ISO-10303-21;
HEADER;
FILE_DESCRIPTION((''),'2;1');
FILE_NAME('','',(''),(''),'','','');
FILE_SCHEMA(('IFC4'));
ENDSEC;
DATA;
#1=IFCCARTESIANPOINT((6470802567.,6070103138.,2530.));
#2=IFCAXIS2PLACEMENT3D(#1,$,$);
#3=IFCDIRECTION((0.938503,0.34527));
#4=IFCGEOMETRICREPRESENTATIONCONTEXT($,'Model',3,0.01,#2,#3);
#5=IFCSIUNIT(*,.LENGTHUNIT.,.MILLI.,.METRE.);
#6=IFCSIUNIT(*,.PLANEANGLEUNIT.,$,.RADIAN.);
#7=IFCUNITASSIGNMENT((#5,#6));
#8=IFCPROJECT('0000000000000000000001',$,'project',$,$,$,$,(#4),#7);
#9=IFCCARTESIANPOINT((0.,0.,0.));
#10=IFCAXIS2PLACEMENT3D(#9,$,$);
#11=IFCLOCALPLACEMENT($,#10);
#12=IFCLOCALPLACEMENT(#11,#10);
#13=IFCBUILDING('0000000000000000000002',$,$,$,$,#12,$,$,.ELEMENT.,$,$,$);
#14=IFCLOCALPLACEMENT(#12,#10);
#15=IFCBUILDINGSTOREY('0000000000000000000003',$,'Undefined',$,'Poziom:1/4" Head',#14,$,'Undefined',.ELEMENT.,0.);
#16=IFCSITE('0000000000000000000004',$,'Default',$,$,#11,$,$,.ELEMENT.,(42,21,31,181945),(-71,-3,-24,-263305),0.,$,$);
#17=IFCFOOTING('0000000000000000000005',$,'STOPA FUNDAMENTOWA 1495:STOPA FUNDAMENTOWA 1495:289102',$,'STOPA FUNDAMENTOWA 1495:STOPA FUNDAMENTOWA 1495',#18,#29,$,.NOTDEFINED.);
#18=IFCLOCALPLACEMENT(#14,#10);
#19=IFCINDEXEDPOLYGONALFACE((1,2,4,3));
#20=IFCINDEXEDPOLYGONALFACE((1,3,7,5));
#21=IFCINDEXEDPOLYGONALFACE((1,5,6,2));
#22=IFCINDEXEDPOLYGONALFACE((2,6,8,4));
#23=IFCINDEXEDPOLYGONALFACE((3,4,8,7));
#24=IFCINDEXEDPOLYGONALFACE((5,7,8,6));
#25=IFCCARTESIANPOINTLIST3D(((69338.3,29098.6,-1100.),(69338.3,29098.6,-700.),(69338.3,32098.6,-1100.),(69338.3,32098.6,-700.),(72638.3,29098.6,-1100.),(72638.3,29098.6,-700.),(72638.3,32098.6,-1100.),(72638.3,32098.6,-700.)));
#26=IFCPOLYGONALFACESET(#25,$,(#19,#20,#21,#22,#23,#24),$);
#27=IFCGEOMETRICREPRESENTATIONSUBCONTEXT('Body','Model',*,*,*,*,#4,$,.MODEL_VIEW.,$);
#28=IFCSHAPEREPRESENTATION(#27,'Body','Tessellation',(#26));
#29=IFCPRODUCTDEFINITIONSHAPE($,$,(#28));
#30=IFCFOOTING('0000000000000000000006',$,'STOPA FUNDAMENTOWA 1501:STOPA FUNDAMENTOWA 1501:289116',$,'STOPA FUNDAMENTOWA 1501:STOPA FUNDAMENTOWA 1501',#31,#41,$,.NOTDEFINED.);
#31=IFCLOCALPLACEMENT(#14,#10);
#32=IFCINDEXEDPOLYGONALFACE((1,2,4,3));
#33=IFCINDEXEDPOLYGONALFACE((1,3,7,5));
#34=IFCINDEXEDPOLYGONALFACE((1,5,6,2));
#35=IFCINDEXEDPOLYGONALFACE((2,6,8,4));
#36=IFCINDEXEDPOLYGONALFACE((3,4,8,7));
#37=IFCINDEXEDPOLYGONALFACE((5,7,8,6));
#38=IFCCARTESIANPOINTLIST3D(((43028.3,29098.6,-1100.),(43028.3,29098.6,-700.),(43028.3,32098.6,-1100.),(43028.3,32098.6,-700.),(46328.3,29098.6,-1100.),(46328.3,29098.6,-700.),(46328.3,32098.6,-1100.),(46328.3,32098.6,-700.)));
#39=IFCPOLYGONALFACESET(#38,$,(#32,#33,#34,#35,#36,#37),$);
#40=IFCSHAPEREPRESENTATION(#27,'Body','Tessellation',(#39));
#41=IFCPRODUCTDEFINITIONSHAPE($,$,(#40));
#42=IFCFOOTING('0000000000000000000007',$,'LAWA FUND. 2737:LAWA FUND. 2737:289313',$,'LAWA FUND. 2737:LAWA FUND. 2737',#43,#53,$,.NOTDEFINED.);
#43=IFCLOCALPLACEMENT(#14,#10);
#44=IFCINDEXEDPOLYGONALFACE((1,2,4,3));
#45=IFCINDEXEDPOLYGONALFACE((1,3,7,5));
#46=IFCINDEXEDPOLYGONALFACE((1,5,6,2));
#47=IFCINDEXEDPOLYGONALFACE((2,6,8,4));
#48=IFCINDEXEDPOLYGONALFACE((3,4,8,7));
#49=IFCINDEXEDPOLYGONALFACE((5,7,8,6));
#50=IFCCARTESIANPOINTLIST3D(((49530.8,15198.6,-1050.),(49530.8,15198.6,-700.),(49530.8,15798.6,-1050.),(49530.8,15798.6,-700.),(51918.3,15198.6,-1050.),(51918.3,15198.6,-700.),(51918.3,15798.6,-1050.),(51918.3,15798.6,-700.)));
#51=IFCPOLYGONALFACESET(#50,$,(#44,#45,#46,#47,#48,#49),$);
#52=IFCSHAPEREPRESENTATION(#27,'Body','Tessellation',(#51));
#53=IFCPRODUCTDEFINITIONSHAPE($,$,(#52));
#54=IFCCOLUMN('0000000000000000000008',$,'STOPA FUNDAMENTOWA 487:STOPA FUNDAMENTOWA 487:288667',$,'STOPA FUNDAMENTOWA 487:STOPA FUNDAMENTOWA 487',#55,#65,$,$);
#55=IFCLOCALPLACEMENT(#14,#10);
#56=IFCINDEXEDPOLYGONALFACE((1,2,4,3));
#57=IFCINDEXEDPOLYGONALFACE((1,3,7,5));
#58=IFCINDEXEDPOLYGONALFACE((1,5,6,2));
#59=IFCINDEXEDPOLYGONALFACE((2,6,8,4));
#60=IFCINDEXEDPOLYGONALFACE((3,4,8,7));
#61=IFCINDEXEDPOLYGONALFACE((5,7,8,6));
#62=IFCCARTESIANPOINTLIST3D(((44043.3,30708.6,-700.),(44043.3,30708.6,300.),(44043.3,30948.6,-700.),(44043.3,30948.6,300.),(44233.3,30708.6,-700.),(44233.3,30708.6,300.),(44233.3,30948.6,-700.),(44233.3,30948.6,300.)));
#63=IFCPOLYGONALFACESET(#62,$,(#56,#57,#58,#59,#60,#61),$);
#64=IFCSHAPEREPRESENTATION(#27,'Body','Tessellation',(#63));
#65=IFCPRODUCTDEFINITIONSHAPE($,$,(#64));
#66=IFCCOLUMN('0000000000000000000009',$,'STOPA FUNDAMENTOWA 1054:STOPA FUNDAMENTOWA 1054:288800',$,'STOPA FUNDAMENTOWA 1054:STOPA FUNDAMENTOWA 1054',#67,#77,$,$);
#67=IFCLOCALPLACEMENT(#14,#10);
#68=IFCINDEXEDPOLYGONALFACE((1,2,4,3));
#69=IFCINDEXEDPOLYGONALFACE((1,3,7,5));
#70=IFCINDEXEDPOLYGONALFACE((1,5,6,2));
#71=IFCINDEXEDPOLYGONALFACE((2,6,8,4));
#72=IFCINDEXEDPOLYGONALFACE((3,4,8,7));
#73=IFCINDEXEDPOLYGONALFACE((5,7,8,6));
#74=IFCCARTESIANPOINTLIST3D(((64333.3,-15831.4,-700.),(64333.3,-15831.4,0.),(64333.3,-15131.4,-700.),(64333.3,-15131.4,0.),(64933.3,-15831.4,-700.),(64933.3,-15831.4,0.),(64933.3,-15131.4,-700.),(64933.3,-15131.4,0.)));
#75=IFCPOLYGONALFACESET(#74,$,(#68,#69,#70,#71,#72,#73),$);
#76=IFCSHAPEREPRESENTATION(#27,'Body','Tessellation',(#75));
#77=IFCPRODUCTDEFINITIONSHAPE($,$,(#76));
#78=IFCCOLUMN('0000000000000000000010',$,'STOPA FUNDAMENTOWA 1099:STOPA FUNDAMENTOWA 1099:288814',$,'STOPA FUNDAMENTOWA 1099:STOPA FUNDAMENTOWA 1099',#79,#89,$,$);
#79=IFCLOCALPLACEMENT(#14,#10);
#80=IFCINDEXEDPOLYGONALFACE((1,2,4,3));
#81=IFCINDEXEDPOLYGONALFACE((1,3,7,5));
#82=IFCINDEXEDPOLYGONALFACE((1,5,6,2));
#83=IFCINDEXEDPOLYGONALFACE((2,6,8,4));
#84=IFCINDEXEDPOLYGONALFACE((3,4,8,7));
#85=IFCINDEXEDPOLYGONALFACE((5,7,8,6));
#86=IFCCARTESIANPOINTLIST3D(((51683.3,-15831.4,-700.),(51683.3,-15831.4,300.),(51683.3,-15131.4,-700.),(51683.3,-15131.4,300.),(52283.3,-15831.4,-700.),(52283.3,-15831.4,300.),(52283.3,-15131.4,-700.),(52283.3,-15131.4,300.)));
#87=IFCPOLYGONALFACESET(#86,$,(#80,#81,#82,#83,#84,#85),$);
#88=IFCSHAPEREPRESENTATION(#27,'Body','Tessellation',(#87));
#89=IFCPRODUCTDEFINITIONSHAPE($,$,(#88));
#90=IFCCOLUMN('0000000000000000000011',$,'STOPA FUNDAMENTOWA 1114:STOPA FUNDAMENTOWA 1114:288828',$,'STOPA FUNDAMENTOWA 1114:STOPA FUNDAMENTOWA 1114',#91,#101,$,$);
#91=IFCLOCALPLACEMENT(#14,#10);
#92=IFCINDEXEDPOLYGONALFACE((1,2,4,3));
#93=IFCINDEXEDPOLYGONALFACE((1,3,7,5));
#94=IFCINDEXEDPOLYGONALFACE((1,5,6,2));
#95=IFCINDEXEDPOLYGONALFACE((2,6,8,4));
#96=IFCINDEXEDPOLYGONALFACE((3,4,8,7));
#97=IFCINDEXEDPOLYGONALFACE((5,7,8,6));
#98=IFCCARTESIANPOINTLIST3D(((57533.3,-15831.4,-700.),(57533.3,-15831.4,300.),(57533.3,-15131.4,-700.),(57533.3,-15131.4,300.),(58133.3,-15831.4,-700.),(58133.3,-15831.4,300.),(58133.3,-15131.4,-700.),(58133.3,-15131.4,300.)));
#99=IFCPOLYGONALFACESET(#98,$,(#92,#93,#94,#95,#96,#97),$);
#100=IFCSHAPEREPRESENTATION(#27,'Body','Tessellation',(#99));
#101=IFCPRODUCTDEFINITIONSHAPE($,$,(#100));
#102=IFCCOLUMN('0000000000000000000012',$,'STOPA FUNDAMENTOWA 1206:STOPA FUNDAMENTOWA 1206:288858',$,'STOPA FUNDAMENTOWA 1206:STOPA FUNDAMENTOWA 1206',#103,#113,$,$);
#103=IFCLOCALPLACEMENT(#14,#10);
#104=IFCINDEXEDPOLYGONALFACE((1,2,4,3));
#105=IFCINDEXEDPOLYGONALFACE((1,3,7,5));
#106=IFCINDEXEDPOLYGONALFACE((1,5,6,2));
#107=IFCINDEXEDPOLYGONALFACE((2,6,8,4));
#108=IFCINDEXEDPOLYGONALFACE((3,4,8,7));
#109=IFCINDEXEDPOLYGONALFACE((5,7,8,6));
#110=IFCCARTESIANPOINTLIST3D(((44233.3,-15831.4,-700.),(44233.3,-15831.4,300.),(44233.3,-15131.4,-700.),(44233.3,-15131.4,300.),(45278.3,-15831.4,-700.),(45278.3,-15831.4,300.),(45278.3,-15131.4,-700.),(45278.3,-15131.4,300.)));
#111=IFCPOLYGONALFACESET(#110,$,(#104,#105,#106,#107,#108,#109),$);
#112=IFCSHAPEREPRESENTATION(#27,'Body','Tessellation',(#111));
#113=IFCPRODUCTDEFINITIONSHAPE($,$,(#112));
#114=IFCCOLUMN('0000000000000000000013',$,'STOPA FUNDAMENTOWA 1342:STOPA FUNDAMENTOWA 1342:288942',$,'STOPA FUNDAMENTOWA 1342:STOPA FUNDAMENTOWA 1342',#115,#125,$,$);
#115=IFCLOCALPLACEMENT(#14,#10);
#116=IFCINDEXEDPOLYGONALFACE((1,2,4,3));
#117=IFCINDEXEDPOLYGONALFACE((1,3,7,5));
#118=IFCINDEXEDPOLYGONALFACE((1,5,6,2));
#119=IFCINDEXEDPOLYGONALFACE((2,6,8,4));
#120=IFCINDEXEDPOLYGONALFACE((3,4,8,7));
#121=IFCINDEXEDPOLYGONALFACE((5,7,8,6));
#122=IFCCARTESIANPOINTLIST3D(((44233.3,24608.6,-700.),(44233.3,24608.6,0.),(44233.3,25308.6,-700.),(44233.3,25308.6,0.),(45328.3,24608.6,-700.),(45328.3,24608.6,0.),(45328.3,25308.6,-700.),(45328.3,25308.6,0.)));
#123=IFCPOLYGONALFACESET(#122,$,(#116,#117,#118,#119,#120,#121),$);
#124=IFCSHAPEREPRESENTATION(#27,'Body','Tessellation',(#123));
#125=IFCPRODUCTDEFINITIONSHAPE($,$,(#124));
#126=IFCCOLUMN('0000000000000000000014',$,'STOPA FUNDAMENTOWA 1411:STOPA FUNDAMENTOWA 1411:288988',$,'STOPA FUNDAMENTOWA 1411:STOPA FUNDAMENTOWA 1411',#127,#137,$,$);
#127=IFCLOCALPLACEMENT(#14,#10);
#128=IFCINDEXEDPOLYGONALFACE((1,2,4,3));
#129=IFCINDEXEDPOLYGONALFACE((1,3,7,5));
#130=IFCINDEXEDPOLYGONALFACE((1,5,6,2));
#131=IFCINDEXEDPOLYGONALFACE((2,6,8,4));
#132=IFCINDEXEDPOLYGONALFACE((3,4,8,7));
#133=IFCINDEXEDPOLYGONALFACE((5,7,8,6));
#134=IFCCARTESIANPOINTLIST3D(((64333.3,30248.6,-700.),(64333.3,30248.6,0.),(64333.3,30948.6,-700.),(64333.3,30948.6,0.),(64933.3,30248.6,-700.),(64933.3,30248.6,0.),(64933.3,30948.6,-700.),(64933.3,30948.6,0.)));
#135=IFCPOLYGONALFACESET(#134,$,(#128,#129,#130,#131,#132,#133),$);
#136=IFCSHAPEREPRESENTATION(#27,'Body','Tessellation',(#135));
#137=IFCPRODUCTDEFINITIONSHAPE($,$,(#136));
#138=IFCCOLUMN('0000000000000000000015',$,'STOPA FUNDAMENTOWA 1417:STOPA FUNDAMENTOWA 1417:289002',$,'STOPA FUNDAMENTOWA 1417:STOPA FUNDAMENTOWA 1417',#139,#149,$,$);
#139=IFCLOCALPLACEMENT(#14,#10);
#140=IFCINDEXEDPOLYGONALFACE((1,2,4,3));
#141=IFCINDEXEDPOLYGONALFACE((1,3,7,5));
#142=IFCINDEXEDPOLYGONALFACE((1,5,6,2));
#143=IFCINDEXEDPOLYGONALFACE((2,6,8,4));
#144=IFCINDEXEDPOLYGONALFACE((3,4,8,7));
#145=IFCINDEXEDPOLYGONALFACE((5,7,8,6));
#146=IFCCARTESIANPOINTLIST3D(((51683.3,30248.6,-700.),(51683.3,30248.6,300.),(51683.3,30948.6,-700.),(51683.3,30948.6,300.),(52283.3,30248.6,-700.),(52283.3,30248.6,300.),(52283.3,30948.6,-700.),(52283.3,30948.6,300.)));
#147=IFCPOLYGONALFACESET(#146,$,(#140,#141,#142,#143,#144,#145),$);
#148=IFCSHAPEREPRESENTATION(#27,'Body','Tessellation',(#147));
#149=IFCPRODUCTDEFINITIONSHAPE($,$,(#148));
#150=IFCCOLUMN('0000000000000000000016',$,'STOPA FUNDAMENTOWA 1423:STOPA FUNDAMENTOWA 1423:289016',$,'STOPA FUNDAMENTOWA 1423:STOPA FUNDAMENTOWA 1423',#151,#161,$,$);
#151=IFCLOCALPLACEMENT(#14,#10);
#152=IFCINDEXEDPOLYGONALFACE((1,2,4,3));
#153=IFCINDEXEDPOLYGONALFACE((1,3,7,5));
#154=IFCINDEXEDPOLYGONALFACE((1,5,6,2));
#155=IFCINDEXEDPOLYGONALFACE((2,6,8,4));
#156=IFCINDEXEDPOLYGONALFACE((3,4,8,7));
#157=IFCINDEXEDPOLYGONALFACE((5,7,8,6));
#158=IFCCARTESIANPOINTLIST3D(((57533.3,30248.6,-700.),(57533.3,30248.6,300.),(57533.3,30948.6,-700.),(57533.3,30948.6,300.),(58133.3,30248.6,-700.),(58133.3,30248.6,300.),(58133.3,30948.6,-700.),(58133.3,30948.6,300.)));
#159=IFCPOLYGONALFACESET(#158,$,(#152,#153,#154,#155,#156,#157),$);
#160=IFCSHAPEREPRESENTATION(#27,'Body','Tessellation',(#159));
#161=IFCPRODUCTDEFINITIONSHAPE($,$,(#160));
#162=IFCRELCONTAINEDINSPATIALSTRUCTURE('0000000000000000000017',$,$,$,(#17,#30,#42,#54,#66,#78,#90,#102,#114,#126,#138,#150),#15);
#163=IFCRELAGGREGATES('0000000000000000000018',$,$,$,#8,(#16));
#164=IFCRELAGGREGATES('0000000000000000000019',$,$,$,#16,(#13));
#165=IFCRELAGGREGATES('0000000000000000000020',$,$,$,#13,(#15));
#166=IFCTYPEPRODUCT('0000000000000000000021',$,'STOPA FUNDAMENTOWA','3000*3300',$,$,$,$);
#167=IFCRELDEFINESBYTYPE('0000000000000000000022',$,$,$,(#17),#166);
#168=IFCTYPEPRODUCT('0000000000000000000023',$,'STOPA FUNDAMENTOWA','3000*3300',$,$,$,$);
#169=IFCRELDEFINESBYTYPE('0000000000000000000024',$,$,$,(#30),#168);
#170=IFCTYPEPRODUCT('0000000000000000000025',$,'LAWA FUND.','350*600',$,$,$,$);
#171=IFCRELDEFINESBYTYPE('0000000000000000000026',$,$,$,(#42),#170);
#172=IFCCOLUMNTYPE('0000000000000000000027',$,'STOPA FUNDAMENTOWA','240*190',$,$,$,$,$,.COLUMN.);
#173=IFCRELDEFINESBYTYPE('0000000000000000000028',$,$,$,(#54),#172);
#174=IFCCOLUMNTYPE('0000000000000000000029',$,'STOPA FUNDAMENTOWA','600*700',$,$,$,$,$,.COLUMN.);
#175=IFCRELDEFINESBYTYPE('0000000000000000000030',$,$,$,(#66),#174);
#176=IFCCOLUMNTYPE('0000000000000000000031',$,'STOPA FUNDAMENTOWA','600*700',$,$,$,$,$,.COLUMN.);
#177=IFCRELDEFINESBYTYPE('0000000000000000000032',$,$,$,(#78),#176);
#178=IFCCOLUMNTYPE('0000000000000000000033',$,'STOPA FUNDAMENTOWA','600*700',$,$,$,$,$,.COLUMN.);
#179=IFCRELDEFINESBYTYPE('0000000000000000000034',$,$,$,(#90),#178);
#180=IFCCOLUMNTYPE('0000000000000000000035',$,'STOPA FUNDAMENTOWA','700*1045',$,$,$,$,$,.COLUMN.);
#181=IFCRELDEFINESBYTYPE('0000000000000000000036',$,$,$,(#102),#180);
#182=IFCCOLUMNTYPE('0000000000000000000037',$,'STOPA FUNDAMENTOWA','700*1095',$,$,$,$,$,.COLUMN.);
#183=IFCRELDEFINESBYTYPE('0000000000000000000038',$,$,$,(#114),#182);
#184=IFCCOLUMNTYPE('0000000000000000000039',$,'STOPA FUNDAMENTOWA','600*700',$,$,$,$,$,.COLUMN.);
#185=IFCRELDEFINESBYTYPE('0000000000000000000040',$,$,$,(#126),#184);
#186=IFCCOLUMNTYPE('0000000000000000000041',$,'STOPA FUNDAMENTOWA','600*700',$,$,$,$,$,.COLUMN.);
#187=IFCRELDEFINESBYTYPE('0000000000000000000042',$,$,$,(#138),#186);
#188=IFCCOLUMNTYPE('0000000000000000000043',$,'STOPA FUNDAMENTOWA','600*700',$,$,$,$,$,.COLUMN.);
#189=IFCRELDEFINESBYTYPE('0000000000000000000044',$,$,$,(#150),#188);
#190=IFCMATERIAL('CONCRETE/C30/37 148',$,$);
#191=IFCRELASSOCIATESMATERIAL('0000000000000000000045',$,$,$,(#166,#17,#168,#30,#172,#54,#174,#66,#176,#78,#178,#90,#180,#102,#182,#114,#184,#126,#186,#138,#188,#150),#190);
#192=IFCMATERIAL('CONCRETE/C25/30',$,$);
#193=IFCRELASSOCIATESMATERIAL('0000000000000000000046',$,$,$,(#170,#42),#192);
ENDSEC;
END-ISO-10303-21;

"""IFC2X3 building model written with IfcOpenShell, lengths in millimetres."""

from ifc_helpers import new_model, si_unit, direction, frame, frame_2d, origin, origin_2d_with_axis, place, context, subcontext, project, spatial, rectangle, extrude, source, transform, mapped, material, type_object, type_shapes, element, save


model = new_model("IFC2X3")

# Units and contexts
model_context = context("Model", 3, precision=0.01, world=frame((6470802567.0, 6070103138.0, 2530.0)), true_north=direction((0.938503, 0.34527)))
body_context = subcontext(model_context, "Body", "Model", "MODEL_VIEW")
ifc_project = project(units=[si_unit("LENGTHUNIT", "METRE", prefix="MILLI"), si_unit("PLANEANGLEUNIT", "RADIAN")], contexts=[model_context])

# Site, building, storey
site_placement = place(None, origin())
site = spatial("IfcSite", under=ifc_project, at=site_placement, Name="Default", CompositionType="ELEMENT", RefLatitude=(42, 21, 31, 181945), RefLongitude=(-71, -3, -24, -263305), RefElevation=0.0)
building_placement = place(site_placement, origin())
building = spatial("IfcBuilding", under=site, at=building_placement, CompositionType="ELEMENT")
storey_placement = place(building_placement, origin())
storey = spatial("IfcBuildingStorey", under=building, at=storey_placement, Name="Undefined", ObjectType="Poziom:1/4\" Head", LongName="Undefined", CompositionType="ELEMENT", Elevation=0.0)

# Footings
ifc_material_1 = material(Name="CONCRETE/C25/30")
ifc_material_2 = material(Name="CONCRETE/C30/37 148")
type_product_1 = type_object("IfcTypeProduct", Name="STOPA FUNDAMENTOWA", Description="3000*3300", material=ifc_material_2)
shared_shape_1 = source(origin(), body_context, "Body", "SweptSolid", [
    extrude(rectangle(XDim=3000.0, YDim=3300.0, at=origin_2d_with_axis()), frame((70988.3, 30598.6, -1100.0), z_axis=(0.0, 0.0, 1.0), x_axis=(0.0, 1.0, 0.0)), (0.0, 0.0, 1.0), 400.0),
])
type_shapes(type_product_1, [shared_shape_1])
footing_1_placement = place(storey_placement, origin())
element("IfcFooting", 1, at=footing_1_placement, inside=storey, type_object=type_product_1, material=ifc_material_2, Name="STOPA FUNDAMENTOWA 1495:STOPA FUNDAMENTOWA 1495:289102", ObjectType="STOPA FUNDAMENTOWA 1495:STOPA FUNDAMENTOWA 1495", PredefinedType="NOTDEFINED", context=body_context, shape_type="MappedRepresentation", body=[
    mapped(shared_shape_1, transform((0.0, 0.0, 0.0), scale=1.0)),
])
type_product_2 = type_object("IfcTypeProduct", Name="STOPA FUNDAMENTOWA", Description="3000*3300", material=ifc_material_2)
shared_shape_2 = source(origin(), body_context, "Body", "SweptSolid", [
    extrude(rectangle(XDim=3000.0, YDim=3300.0, at=origin_2d_with_axis()), frame((44678.3, 30598.6, -1100.0), z_axis=(0.0, 0.0, 1.0), x_axis=(0.0, 1.0, 0.0)), (0.0, 0.0, 1.0), 400.0),
])
type_shapes(type_product_2, [shared_shape_2])
footing_2_placement = place(storey_placement, origin())
element("IfcFooting", 2, at=footing_2_placement, inside=storey, type_object=type_product_2, material=ifc_material_2, Name="STOPA FUNDAMENTOWA 1501:STOPA FUNDAMENTOWA 1501:289116", ObjectType="STOPA FUNDAMENTOWA 1501:STOPA FUNDAMENTOWA 1501", PredefinedType="NOTDEFINED", context=body_context, shape_type="MappedRepresentation", body=[
    mapped(shared_shape_2, transform((0.0, 0.0, 0.0), scale=1.0)),
])
type_product_3 = type_object("IfcTypeProduct", Name="LAWA FUND.", Description="350*600", material=ifc_material_1)
shared_shape_3 = source(origin(), body_context, "Body", "SweptSolid", [
    extrude(rectangle(XDim=600.0, YDim=2387.5, at=frame_2d((0.0, 0.0), x_axis=(1.0, 0.0))), frame((50724.5, 15498.6, -1050.0), z_axis=(0.0, 0.0, 1.0), x_axis=(0.0, 1.0, 0.0)), (0.0, 0.0, 1.0), 350.0),
])
type_shapes(type_product_3, [shared_shape_3])
footing_3_placement = place(storey_placement, origin())
element("IfcFooting", 3, at=footing_3_placement, inside=storey, type_object=type_product_3, material=ifc_material_1, Name="LAWA FUND. 2737:LAWA FUND. 2737:289313", ObjectType="LAWA FUND. 2737:LAWA FUND. 2737", PredefinedType="NOTDEFINED", context=body_context, shape_type="MappedRepresentation", body=[
    mapped(shared_shape_3, transform((0.0, 0.0, 0.0), scale=1.0)),
])

# Columns
column_type_1 = type_object("IfcColumnType", Name="STOPA FUNDAMENTOWA", Description="240*190", PredefinedType="COLUMN", material=ifc_material_2)
shared_shape_4 = source(origin(), body_context, "Body", "SweptSolid", [
    extrude(rectangle(XDim=240.0, YDim=190.0, at=frame_2d((0.0, 0.0), x_axis=(1.0, 0.0))), frame((44138.3, 30828.6, -700.0), z_axis=(0.0, 0.0, 1.0), x_axis=(0.0, 1.0, 0.0)), (0.0, 0.0, 1.0), 1000.0),
])
type_shapes(column_type_1, [shared_shape_4])
column_1_placement = place(storey_placement, origin())
element("IfcColumn", 4, at=column_1_placement, inside=storey, type_object=column_type_1, material=ifc_material_2, Name="STOPA FUNDAMENTOWA 487:STOPA FUNDAMENTOWA 487:288667", ObjectType="STOPA FUNDAMENTOWA 487:STOPA FUNDAMENTOWA 487", context=body_context, shape_type="MappedRepresentation", body=[
    mapped(shared_shape_4, transform((0.0, 0.0, 0.0), scale=1.0)),
])
column_type_2 = type_object("IfcColumnType", Name="STOPA FUNDAMENTOWA", Description="600*700", PredefinedType="COLUMN", material=ifc_material_2)
shared_shape_5 = source(origin(), body_context, "Body", "SweptSolid", [
    extrude(rectangle(XDim=600.0, YDim=700.0, at=frame_2d((0.0, 0.0), x_axis=(1.0, 0.0))), frame((64633.3, -15481.4, -700.0)), (0.0, 0.0, 1.0), 700.0),
])
type_shapes(column_type_2, [shared_shape_5])
column_2_placement = place(storey_placement, origin())
element("IfcColumn", 5, at=column_2_placement, inside=storey, type_object=column_type_2, material=ifc_material_2, Name="STOPA FUNDAMENTOWA 1054:STOPA FUNDAMENTOWA 1054:288800", ObjectType="STOPA FUNDAMENTOWA 1054:STOPA FUNDAMENTOWA 1054", context=body_context, shape_type="MappedRepresentation", body=[
    mapped(shared_shape_5, transform((0.0, 0.0, 0.0), scale=1.0)),
])
column_type_3 = type_object("IfcColumnType", Name="STOPA FUNDAMENTOWA", Description="600*700", PredefinedType="COLUMN", material=ifc_material_2)
shared_shape_6 = source(origin(), body_context, "Body", "SweptSolid", [
    extrude(rectangle(XDim=600.0, YDim=700.0, at=frame_2d((0.0, 0.0), x_axis=(1.0, 0.0))), frame((51983.3, -15481.4, -700.0)), (0.0, 0.0, 1.0), 1000.0),
])
type_shapes(column_type_3, [shared_shape_6])
column_3_placement = place(storey_placement, origin())
element("IfcColumn", 6, at=column_3_placement, inside=storey, type_object=column_type_3, material=ifc_material_2, Name="STOPA FUNDAMENTOWA 1099:STOPA FUNDAMENTOWA 1099:288814", ObjectType="STOPA FUNDAMENTOWA 1099:STOPA FUNDAMENTOWA 1099", context=body_context, shape_type="MappedRepresentation", body=[
    mapped(shared_shape_6, transform((0.0, 0.0, 0.0), scale=1.0)),
])
column_type_4 = type_object("IfcColumnType", Name="STOPA FUNDAMENTOWA", Description="600*700", PredefinedType="COLUMN", material=ifc_material_2)
shared_shape_7 = source(origin(), body_context, "Body", "SweptSolid", [
    extrude(rectangle(XDim=600.0, YDim=700.0, at=frame_2d((0.0, 0.0), x_axis=(1.0, 0.0))), frame((57833.3, -15481.4, -700.0)), (0.0, 0.0, 1.0), 1000.0),
])
type_shapes(column_type_4, [shared_shape_7])
column_4_placement = place(storey_placement, origin())
element("IfcColumn", 7, at=column_4_placement, inside=storey, type_object=column_type_4, material=ifc_material_2, Name="STOPA FUNDAMENTOWA 1114:STOPA FUNDAMENTOWA 1114:288828", ObjectType="STOPA FUNDAMENTOWA 1114:STOPA FUNDAMENTOWA 1114", context=body_context, shape_type="MappedRepresentation", body=[
    mapped(shared_shape_7, transform((0.0, 0.0, 0.0), scale=1.0)),
])
column_type_5 = type_object("IfcColumnType", Name="STOPA FUNDAMENTOWA", Description="700*1045", PredefinedType="COLUMN", material=ifc_material_2)
shared_shape_8 = source(origin(), body_context, "Body", "SweptSolid", [
    extrude(rectangle(XDim=700.0, YDim=1045.0, at=frame_2d((0.0, 0.0), x_axis=(1.0, 0.0))), frame((44755.8, -15481.4, -700.0), z_axis=(0.0, 0.0, 1.0), x_axis=(0.0, -1.0, 0.0)), (0.0, 0.0, 1.0), 1000.0),
])
type_shapes(column_type_5, [shared_shape_8])
column_5_placement = place(storey_placement, origin())
element("IfcColumn", 8, at=column_5_placement, inside=storey, type_object=column_type_5, material=ifc_material_2, Name="STOPA FUNDAMENTOWA 1206:STOPA FUNDAMENTOWA 1206:288858", ObjectType="STOPA FUNDAMENTOWA 1206:STOPA FUNDAMENTOWA 1206", context=body_context, shape_type="MappedRepresentation", body=[
    mapped(shared_shape_8, transform((0.0, 0.0, 0.0), scale=1.0)),
])
column_type_6 = type_object("IfcColumnType", Name="STOPA FUNDAMENTOWA", Description="700*1095", PredefinedType="COLUMN", material=ifc_material_2)
shared_shape_9 = source(origin(), body_context, "Body", "SweptSolid", [
    extrude(rectangle(XDim=700.0, YDim=1095.0, at=frame_2d((0.0, 0.0), x_axis=(1.0, 0.0))), frame((44780.8, 24958.6, -700.0), z_axis=(0.0, 0.0, 1.0), x_axis=(0.0, 1.0, 0.0)), (0.0, 0.0, 1.0), 700.0),
])
type_shapes(column_type_6, [shared_shape_9])
column_6_placement = place(storey_placement, origin())
element("IfcColumn", 9, at=column_6_placement, inside=storey, type_object=column_type_6, material=ifc_material_2, Name="STOPA FUNDAMENTOWA 1342:STOPA FUNDAMENTOWA 1342:288942", ObjectType="STOPA FUNDAMENTOWA 1342:STOPA FUNDAMENTOWA 1342", context=body_context, shape_type="MappedRepresentation", body=[
    mapped(shared_shape_9, transform((0.0, 0.0, 0.0), scale=1.0)),
])
column_type_7 = type_object("IfcColumnType", Name="STOPA FUNDAMENTOWA", Description="600*700", PredefinedType="COLUMN", material=ifc_material_2)
shared_shape_10 = source(origin(), body_context, "Body", "SweptSolid", [
    extrude(rectangle(XDim=600.0, YDim=700.0, at=origin_2d_with_axis()), frame((64633.3, 30598.6, -700.0)), (0.0, 0.0, 1.0), 700.0),
])
type_shapes(column_type_7, [shared_shape_10])
column_7_placement = place(storey_placement, origin())
element("IfcColumn", 10, at=column_7_placement, inside=storey, type_object=column_type_7, material=ifc_material_2, Name="STOPA FUNDAMENTOWA 1411:STOPA FUNDAMENTOWA 1411:288988", ObjectType="STOPA FUNDAMENTOWA 1411:STOPA FUNDAMENTOWA 1411", context=body_context, shape_type="MappedRepresentation", body=[
    mapped(shared_shape_10, transform((0.0, 0.0, 0.0), scale=1.0)),
])
column_type_8 = type_object("IfcColumnType", Name="STOPA FUNDAMENTOWA", Description="600*700", PredefinedType="COLUMN", material=ifc_material_2)
shared_shape_11 = source(origin(), body_context, "Body", "SweptSolid", [
    extrude(rectangle(XDim=600.0, YDim=700.0, at=frame_2d((0.0, 0.0), x_axis=(1.0, 0.0))), frame((51983.3, 30598.6, -700.0)), (0.0, 0.0, 1.0), 1000.0),
])
type_shapes(column_type_8, [shared_shape_11])
column_8_placement = place(storey_placement, origin())
element("IfcColumn", 11, at=column_8_placement, inside=storey, type_object=column_type_8, material=ifc_material_2, Name="STOPA FUNDAMENTOWA 1417:STOPA FUNDAMENTOWA 1417:289002", ObjectType="STOPA FUNDAMENTOWA 1417:STOPA FUNDAMENTOWA 1417", context=body_context, shape_type="MappedRepresentation", body=[
    mapped(shared_shape_11, transform((0.0, 0.0, 0.0), scale=1.0)),
])
column_type_9 = type_object("IfcColumnType", Name="STOPA FUNDAMENTOWA", Description="600*700", PredefinedType="COLUMN", material=ifc_material_2)
shared_shape_12 = source(origin(), body_context, "Body", "SweptSolid", [
    extrude(rectangle(XDim=600.0, YDim=700.0, at=origin_2d_with_axis()), frame((57833.3, 30598.6, -700.0)), (0.0, 0.0, 1.0), 1000.0),
])
type_shapes(column_type_9, [shared_shape_12])
column_9_placement = place(storey_placement, origin())
element("IfcColumn", 12, at=column_9_placement, inside=storey, type_object=column_type_9, material=ifc_material_2, Name="STOPA FUNDAMENTOWA 1423:STOPA FUNDAMENTOWA 1423:289016", ObjectType="STOPA FUNDAMENTOWA 1423:STOPA FUNDAMENTOWA 1423", context=body_context, shape_type="MappedRepresentation", body=[
    mapped(shared_shape_12, transform((0.0, 0.0, 0.0), scale=1.0)),
])

save(model, "model.ifc")
